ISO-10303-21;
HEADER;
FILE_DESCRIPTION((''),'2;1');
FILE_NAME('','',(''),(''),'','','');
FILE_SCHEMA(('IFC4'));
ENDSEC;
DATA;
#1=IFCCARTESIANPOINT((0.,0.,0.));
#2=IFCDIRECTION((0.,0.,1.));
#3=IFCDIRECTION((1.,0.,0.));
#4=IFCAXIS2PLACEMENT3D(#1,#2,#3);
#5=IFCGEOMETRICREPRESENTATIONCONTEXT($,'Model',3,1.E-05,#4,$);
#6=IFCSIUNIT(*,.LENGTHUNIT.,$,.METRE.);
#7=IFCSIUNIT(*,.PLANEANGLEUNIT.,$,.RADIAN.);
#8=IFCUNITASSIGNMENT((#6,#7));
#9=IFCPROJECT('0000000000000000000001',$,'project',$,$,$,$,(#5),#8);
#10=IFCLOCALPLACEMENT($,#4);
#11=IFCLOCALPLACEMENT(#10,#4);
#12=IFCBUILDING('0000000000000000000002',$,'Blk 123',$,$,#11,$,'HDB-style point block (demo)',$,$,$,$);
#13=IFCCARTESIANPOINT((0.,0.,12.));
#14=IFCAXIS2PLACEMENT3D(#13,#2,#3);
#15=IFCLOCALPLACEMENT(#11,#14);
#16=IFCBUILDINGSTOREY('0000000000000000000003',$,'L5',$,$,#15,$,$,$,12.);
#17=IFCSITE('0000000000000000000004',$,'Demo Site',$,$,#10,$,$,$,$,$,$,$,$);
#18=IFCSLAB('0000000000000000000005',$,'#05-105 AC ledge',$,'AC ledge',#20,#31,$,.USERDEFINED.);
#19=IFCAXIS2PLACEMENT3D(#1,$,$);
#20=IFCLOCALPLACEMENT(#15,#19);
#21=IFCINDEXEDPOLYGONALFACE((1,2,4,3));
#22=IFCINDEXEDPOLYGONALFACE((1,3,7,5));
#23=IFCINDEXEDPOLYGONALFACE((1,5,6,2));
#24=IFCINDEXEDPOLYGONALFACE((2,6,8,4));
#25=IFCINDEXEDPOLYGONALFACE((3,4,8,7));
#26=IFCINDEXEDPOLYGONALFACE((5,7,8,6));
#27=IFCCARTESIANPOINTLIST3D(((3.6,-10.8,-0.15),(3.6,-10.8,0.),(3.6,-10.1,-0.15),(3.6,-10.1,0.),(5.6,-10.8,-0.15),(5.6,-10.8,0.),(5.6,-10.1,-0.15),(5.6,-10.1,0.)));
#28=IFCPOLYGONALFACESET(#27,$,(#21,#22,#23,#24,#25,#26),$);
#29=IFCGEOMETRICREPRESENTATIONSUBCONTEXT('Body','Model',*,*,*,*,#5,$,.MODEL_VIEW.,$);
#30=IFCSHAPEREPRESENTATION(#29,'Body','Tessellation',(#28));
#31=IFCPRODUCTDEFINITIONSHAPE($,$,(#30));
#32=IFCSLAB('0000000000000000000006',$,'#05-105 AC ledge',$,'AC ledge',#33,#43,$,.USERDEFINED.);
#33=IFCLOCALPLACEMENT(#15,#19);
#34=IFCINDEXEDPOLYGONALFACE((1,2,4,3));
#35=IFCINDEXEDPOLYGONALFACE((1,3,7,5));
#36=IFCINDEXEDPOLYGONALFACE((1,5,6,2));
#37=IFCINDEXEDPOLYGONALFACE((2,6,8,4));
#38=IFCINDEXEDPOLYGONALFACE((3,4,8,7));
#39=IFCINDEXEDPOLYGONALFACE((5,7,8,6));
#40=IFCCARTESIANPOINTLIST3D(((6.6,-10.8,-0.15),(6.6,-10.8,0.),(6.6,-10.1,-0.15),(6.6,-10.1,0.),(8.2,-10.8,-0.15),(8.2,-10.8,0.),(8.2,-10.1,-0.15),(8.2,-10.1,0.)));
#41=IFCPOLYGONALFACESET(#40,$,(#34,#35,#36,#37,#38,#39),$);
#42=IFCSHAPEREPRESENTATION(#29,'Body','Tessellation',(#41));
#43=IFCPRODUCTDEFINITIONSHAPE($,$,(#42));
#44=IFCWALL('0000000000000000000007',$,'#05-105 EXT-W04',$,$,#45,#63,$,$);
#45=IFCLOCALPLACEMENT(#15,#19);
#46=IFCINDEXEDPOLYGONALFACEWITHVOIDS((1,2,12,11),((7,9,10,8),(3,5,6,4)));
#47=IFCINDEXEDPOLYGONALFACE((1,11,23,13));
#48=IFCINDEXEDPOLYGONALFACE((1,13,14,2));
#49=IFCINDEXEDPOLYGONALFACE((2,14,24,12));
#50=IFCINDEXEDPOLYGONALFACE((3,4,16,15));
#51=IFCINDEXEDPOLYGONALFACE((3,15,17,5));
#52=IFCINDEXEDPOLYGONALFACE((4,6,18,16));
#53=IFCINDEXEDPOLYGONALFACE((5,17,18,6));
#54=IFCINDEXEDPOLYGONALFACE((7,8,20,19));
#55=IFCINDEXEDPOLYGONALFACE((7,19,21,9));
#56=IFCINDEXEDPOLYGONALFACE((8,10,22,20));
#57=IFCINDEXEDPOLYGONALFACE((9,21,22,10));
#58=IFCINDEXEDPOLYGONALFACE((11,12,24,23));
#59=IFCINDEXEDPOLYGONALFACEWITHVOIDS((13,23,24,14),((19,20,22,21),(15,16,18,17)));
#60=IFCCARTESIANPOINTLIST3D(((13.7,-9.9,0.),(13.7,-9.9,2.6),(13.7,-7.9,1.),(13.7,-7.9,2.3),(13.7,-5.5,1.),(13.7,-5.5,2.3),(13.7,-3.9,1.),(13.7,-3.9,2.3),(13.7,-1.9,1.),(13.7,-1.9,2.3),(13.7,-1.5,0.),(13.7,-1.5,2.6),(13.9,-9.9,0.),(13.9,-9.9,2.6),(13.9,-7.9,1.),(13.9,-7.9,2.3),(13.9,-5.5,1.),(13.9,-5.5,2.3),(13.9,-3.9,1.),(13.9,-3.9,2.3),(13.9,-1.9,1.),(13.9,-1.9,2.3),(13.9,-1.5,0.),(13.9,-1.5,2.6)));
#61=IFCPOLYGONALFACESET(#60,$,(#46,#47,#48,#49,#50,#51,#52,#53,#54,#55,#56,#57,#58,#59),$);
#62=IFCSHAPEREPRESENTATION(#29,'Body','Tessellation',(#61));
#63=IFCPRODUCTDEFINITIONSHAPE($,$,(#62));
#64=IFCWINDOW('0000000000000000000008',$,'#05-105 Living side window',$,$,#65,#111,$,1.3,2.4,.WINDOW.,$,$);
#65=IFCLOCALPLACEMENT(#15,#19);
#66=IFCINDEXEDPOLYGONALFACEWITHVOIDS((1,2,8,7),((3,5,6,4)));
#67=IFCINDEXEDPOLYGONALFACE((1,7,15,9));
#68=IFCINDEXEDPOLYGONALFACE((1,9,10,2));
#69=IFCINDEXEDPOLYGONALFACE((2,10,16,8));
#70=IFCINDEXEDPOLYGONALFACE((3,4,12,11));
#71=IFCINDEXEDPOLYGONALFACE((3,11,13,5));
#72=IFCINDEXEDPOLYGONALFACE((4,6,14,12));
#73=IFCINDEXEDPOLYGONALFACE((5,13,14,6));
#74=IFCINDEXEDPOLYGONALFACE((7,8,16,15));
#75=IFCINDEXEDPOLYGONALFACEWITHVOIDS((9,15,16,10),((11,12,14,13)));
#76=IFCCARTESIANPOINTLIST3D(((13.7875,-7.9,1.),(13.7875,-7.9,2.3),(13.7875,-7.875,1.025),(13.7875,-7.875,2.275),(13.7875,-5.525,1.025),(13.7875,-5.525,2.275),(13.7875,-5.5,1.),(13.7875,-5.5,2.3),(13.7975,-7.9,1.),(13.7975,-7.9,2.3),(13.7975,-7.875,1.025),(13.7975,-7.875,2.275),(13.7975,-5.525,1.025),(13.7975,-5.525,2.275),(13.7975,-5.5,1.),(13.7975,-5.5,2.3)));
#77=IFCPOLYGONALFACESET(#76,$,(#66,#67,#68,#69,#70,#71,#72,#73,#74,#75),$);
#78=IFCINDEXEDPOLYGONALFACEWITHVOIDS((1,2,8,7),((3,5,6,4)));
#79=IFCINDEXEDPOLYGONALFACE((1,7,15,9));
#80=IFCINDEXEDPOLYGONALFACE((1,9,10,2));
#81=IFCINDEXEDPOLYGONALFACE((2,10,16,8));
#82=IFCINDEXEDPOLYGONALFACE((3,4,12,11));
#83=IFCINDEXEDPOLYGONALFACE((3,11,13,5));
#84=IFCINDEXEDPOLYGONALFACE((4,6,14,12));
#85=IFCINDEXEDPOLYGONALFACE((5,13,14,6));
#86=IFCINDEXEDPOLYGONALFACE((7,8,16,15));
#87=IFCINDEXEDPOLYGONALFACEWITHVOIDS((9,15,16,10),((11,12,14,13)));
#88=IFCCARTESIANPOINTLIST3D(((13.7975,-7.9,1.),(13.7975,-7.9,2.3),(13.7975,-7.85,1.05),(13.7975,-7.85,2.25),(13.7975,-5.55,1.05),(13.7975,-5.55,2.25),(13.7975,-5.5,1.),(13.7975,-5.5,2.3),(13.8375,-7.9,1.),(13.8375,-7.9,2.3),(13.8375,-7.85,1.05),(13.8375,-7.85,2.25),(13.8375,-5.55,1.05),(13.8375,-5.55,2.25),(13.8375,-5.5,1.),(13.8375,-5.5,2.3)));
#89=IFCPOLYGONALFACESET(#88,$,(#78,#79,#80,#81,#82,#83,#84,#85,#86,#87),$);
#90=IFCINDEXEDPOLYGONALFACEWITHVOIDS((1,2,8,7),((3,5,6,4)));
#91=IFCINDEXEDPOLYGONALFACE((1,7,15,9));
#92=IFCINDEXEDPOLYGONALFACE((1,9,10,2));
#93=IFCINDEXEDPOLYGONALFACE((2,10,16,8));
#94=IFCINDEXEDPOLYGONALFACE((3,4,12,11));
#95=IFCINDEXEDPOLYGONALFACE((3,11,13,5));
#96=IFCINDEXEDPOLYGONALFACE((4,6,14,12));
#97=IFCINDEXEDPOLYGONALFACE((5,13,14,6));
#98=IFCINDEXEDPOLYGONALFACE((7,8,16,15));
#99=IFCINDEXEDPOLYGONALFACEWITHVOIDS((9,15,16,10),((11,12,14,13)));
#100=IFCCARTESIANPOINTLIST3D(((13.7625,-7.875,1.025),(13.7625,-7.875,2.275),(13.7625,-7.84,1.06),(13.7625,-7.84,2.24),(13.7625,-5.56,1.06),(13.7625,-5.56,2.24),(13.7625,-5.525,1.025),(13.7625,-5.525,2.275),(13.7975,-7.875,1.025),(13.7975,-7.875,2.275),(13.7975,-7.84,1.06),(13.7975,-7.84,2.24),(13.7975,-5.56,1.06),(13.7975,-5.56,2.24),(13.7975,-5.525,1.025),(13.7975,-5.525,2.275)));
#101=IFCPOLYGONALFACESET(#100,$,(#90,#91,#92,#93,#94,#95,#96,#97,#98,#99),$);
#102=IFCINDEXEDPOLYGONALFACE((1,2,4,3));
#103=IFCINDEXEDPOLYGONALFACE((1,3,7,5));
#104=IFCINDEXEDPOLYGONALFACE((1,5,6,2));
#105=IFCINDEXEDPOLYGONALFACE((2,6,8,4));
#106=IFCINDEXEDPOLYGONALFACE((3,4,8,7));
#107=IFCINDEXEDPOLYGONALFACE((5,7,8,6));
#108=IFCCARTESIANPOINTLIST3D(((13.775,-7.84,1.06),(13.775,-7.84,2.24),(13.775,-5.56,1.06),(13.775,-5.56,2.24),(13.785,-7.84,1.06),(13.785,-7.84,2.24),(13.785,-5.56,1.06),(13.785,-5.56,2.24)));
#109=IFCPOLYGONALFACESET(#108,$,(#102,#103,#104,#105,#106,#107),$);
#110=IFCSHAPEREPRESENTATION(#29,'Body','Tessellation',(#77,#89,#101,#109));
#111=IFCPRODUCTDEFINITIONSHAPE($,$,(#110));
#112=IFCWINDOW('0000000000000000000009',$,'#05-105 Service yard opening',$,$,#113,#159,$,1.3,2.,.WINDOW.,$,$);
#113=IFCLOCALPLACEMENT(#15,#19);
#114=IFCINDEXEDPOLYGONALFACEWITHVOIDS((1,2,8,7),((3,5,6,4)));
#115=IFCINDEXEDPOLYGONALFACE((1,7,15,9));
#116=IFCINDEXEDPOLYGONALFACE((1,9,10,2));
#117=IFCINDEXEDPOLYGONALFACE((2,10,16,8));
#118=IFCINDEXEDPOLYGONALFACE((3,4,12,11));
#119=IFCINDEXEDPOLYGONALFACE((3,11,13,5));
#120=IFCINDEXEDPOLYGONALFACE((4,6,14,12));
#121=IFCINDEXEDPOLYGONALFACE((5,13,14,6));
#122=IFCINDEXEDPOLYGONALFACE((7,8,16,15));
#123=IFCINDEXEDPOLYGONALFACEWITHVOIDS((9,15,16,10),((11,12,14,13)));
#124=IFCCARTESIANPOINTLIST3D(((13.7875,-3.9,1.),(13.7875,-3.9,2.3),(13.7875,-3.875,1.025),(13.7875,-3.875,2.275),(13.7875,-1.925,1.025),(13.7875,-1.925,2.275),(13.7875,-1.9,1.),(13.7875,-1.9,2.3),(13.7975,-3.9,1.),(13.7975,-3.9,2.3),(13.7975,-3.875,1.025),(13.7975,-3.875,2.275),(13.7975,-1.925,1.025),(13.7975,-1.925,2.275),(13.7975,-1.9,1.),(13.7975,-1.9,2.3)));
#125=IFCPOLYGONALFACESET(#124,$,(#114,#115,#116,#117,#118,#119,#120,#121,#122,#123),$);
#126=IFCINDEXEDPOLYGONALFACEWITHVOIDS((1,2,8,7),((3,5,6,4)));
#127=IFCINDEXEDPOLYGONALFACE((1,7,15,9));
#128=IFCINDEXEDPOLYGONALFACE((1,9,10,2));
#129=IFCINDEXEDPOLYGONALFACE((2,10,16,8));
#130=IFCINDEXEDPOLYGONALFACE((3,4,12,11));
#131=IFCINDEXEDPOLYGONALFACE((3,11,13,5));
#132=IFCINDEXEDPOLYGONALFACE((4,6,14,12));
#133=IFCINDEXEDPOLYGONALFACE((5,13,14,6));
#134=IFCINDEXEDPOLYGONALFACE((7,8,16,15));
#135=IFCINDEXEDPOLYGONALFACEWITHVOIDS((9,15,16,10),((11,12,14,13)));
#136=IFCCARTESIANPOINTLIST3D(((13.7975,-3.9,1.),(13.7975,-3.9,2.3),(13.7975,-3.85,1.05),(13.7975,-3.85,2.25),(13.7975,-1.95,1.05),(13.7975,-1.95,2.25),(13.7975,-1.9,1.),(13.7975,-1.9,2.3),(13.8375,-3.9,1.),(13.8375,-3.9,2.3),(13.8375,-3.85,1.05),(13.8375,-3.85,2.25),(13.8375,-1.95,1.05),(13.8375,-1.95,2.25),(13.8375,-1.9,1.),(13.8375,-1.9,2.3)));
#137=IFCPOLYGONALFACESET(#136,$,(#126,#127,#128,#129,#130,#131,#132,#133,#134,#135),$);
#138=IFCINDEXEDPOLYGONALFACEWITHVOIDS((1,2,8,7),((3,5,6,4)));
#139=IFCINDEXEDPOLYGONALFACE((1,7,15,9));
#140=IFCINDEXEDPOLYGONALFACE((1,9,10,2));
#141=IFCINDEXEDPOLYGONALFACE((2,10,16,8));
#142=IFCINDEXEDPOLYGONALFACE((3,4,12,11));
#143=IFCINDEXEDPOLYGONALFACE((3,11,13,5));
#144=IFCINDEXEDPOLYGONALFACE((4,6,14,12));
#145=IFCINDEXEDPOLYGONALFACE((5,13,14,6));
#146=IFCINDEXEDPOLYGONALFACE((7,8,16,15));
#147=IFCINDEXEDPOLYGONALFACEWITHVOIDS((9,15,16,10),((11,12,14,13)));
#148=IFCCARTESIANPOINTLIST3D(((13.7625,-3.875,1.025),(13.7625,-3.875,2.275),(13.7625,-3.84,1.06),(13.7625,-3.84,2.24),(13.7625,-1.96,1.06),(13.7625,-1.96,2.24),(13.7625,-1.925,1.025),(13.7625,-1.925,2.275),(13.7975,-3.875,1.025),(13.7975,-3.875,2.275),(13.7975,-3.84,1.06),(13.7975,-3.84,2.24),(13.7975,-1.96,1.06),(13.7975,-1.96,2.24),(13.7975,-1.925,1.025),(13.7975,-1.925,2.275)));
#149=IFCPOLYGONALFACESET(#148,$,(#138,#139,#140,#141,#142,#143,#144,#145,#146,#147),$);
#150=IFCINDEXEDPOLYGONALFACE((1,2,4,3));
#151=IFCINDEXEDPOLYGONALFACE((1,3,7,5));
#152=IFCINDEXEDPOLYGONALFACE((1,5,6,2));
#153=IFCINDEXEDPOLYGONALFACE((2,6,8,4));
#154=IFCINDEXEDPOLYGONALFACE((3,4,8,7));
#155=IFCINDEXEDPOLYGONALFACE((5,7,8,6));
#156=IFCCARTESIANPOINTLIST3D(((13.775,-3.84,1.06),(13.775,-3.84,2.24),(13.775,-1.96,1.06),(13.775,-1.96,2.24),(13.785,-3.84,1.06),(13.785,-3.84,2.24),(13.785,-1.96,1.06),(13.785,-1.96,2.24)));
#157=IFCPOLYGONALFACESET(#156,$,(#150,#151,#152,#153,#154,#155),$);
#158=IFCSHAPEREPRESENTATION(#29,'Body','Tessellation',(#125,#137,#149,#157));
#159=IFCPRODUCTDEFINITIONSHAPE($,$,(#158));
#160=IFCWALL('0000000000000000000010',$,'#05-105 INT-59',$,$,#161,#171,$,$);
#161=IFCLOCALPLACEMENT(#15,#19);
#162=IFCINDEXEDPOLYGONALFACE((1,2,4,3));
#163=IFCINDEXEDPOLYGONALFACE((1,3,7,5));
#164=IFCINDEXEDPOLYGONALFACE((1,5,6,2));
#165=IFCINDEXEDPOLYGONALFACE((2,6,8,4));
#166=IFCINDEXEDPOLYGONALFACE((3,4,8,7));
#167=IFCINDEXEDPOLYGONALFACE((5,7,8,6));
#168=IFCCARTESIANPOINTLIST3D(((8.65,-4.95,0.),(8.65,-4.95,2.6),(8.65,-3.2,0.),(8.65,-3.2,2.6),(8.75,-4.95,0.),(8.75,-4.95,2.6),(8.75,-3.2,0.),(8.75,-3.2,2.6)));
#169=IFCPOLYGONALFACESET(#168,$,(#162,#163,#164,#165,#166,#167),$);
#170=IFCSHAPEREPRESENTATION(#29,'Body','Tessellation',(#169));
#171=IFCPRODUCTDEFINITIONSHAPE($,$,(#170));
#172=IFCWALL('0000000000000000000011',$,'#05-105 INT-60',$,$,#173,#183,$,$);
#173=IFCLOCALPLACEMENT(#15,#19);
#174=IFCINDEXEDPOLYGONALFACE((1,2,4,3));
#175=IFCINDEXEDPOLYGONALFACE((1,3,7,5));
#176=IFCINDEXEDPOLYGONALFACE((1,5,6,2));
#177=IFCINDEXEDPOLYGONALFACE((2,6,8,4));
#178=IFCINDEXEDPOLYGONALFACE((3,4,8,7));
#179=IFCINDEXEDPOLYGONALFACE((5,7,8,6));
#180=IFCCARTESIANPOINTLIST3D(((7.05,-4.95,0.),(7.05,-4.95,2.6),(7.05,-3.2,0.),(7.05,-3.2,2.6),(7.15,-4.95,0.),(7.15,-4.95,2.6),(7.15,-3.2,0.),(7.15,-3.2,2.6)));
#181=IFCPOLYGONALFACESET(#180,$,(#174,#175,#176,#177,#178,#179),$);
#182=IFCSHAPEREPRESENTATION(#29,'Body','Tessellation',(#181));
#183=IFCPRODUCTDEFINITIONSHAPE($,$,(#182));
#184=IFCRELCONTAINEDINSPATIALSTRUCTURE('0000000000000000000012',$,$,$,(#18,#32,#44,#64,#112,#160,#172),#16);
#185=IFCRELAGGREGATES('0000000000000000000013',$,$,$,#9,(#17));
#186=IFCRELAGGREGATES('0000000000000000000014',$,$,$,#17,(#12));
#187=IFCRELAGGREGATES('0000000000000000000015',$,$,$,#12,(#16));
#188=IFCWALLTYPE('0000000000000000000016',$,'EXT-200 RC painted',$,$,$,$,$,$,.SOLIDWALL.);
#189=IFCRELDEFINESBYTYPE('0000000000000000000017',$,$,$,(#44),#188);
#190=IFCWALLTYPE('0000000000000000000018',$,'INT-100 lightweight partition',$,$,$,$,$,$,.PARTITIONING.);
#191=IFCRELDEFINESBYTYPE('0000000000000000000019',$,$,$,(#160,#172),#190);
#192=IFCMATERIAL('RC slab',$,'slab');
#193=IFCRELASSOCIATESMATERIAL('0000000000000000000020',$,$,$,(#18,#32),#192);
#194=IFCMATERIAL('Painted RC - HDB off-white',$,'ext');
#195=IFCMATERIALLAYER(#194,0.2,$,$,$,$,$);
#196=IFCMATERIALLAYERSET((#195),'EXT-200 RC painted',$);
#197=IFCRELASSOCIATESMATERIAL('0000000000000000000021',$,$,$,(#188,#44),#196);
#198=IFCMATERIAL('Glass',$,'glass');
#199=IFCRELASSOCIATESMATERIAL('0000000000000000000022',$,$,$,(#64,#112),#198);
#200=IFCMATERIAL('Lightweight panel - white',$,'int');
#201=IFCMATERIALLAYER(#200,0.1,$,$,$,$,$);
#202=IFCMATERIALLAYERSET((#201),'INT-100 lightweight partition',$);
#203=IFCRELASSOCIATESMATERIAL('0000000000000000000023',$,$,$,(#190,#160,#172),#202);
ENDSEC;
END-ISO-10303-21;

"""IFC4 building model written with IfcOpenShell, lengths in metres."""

from ifc_helpers import new_model, si_unit, frame, origin, origin_with_axes, place, context, subcontext, project, spatial, polyline, line, indexed_curve, outline, extrude, material, layer, layer_set, layer_usage, type_object, element, fill, save


model = new_model("IFC4")

# Units and contexts
model_context = context("Model", 3, precision=1e-05, world=origin_with_axes())
body_context = subcontext(model_context, "Body", "Model", "MODEL_VIEW")
ifc_project = project(units=[si_unit("LENGTHUNIT", "METRE"), si_unit("PLANEANGLEUNIT", "RADIAN")], contexts=[model_context])

# Site, building, storey
site_placement = place(None, origin_with_axes())
site = spatial("IfcSite", under=ifc_project, at=site_placement, Name="Demo Site")
building_placement = place(site_placement, origin_with_axes())
building = spatial("IfcBuilding", under=site, at=building_placement, Name="Blk 123", LongName="HDB-style point block (demo)")
storey_placement = place(building_placement, frame((0.0, 0.0, 12.0), z_axis=(0.0, 0.0, 1.0), x_axis=(1.0, 0.0, 0.0)))
storey = spatial("IfcBuildingStorey", under=building, at=storey_placement, Name="L5", Elevation=12.0)

# Slabs
ifc_material_1 = material(Name="RC slab", Category="slab")
slab_1_placement = place(storey_placement, frame((4.6, -10.45, -0.15), z_axis=(0.0, 0.0, 1.0), x_axis=(1.0, 0.0, 0.0)))
element("IfcSlab", 1, at=slab_1_placement, inside=storey, material=ifc_material_1, Name="#05-105 AC ledge", ObjectType="AC ledge", PredefinedType="USERDEFINED", context=body_context, shape_type="SweptSolid", body=[
    extrude(outline(polyline([(1.0, 0.35), (-1.0, 0.35), (-1.0, -0.35), (1.0, -0.35), (1.0, 0.35)])), origin(), (0.0, 0.0, 1.0), 0.15),
])
slab_2_placement = place(storey_placement, frame((7.4, -10.45, -0.15), z_axis=(0.0, 0.0, 1.0), x_axis=(1.0, 0.0, 0.0)))
element("IfcSlab", 2, at=slab_2_placement, inside=storey, material=ifc_material_1, Name="#05-105 AC ledge", ObjectType="AC ledge", PredefinedType="USERDEFINED", context=body_context, shape_type="SweptSolid", body=[
    extrude(outline(polyline([(0.8, 0.35), (-0.8, 0.35), (-0.8, -0.35), (0.8, -0.35), (0.8, 0.35)])), origin(), (0.0, 0.0, 1.0), 0.15),
])

# Wall, openings, windows
ifc_material_2 = material(Name="Painted RC - HDB off-white", Category="ext")
ifc_layer_1 = layer(ifc_material_2, 0.2)
ifc_layer_set_1 = layer_set([ifc_layer_1], Name="EXT-200 RC painted")
ifc_layer_usage_1 = layer_usage(ifc_layer_set_1, "AXIS2", "POSITIVE", 0.0)
wall_type_1 = type_object("IfcWallType", Name="EXT-200 RC painted", PredefinedType="SOLIDWALL", material=ifc_layer_set_1)
wall_1_placement = place(storey_placement, frame((13.9, -9.9, 0.0), z_axis=(0.0, 0.0, 1.0), x_axis=(0.0, 1.0, 0.0)))
wall_1 = element("IfcWall", 3, at=wall_1_placement, inside=storey, type_object=wall_type_1, material=ifc_layer_usage_1, Name="#05-105 EXT-W04", context=body_context, shape_type="SweptSolid", body=[
    extrude(outline(indexed_curve([(0.0, 0.0), (0.0, 0.2), (8.4, 0.2), (8.4, 0.0), (0.0, 0.0)], self_intersect=False)), origin_with_axes(), (0.0, 0.0, 1.0), 2.6),
])
opening_1_placement = place(wall_1_placement, frame((2.0, -0.1, 1.0), z_axis=(0.0, 0.0, 1.0), x_axis=(1.0, 0.0, 0.0)))
opening_1 = element("IfcOpeningElement", 4, at=opening_1_placement, cuts=wall_1, context=body_context, shape_type="SweptSolid", body=[
    extrude(outline(indexed_curve([(0.0, 0.0), (0.0, 0.4), (2.4, 0.4), (2.4, 0.0), (0.0, 0.0)], self_intersect=False)), origin_with_axes(), (0.0, 0.0, 1.0), 1.3),
])
opening_2_placement = place(wall_1_placement, frame((6.0, -0.1, 1.0), z_axis=(0.0, 0.0, 1.0), x_axis=(1.0, 0.0, 0.0)))
opening_2 = element("IfcOpeningElement", 5, at=opening_2_placement, cuts=wall_1, context=body_context, shape_type="SweptSolid", body=[
    extrude(outline(indexed_curve([(0.0, 0.0), (0.0, 0.4), (2.0, 0.4), (2.0, 0.0), (0.0, 0.0)], self_intersect=False)), origin_with_axes(), (0.0, 0.0, 1.0), 1.3),
])
ifc_material_3 = material(Name="Glass", Category="glass")
window_1_placement = place(opening_1_placement, frame((0.0, 0.1125, 0.0), z_axis=(0.0, 0.0, 1.0), x_axis=(1.0, 0.0, 0.0)))
window_1 = element("IfcWindow", 6, at=window_1_placement, inside=storey, material=ifc_material_3, Name="#05-105 Living side window", OverallHeight=1.3, OverallWidth=2.4, PredefinedType="WINDOW", context=body_context, shape_type="SweptSolid", body=[
    extrude(outline(indexed_curve([(0.0, 0.0), (2.4, 0.0), (2.4, 1.3), (0.0, 1.3)], segments=[line(1, 2, 3, 4, 1)]), holes=[indexed_curve([(0.025, 0.025), (2.375, 0.025), (2.375, 1.275), (0.025, 1.275)], segments=[line(1, 2, 3, 4, 1)])]), frame((0.0, 0.09, 0.0), z_axis=(0.0, -1.0, 0.0), x_axis=(1.0, 0.0, 0.0)), (0.0, 0.0, -1.0), 0.01),
    extrude(outline(indexed_curve([(0.0, 0.0), (2.4, 0.0), (2.4, 1.3), (0.0, 1.3)], segments=[line(1, 2, 3, 4, 1)]), holes=[indexed_curve([(0.05, 0.05), (2.35, 0.05), (2.35, 1.25), (0.05, 1.25)], segments=[line(1, 2, 3, 4, 1)])]), frame((0.0, 0.05, 0.0), z_axis=(0.0, -1.0, 0.0), x_axis=(1.0, 0.0, 0.0)), (0.0, 0.0, -1.0), 0.04),
    extrude(outline(indexed_curve([(0.0, 0.0), (2.35, 0.0), (2.35, 1.25), (0.0, 1.25)], segments=[line(1, 2, 3, 4, 1)]), holes=[indexed_curve([(0.035, 0.035), (2.315, 0.035), (2.315, 1.215), (0.035, 1.215)], segments=[line(1, 2, 3, 4, 1)])]), frame((0.025, 0.09, 0.025), z_axis=(0.0, -1.0, 0.0), x_axis=(1.0, 0.0, 0.0)), (0.0, 0.0, -1.0), 0.035),
    extrude(outline(indexed_curve([(0.035, 0.035), (2.315, 0.035), (2.315, 1.215), (0.035, 1.215)], segments=[line(1, 2, 3, 4, 1)])), frame((0.025, 0.1025, 0.025), z_axis=(0.0, -1.0, 0.0), x_axis=(1.0, 0.0, 0.0)), (0.0, 0.0, -1.0), 0.01),
])
fill(opening_1, window_1)
window_2_placement = place(opening_2_placement, frame((0.0, 0.1125, 0.0), z_axis=(0.0, 0.0, 1.0), x_axis=(1.0, 0.0, 0.0)))
window_2 = element("IfcWindow", 7, at=window_2_placement, inside=storey, material=ifc_material_3, Name="#05-105 Service yard opening", OverallHeight=1.3, OverallWidth=2.0, PredefinedType="WINDOW", context=body_context, shape_type="SweptSolid", body=[
    extrude(outline(indexed_curve([(0.0, 0.0), (2.0, 0.0), (2.0, 1.3), (0.0, 1.3)], segments=[line(1, 2, 3, 4, 1)]), holes=[indexed_curve([(0.025, 0.025), (1.975, 0.025), (1.975, 1.275), (0.025, 1.275)], segments=[line(1, 2, 3, 4, 1)])]), frame((0.0, 0.09, 0.0), z_axis=(0.0, -1.0, 0.0), x_axis=(1.0, 0.0, 0.0)), (0.0, 0.0, -1.0), 0.01),
    extrude(outline(indexed_curve([(0.0, 0.0), (2.0, 0.0), (2.0, 1.3), (0.0, 1.3)], segments=[line(1, 2, 3, 4, 1)]), holes=[indexed_curve([(0.05, 0.05), (1.95, 0.05), (1.95, 1.25), (0.05, 1.25)], segments=[line(1, 2, 3, 4, 1)])]), frame((0.0, 0.05, 0.0), z_axis=(0.0, -1.0, 0.0), x_axis=(1.0, 0.0, 0.0)), (0.0, 0.0, -1.0), 0.04),
    extrude(outline(indexed_curve([(0.0, 0.0), (1.95, 0.0), (1.95, 1.25), (0.0, 1.25)], segments=[line(1, 2, 3, 4, 1)]), holes=[indexed_curve([(0.035, 0.035), (1.915, 0.035), (1.915, 1.215), (0.035, 1.215)], segments=[line(1, 2, 3, 4, 1)])]), frame((0.025, 0.09, 0.025), z_axis=(0.0, -1.0, 0.0), x_axis=(1.0, 0.0, 0.0)), (0.0, 0.0, -1.0), 0.035),
    extrude(outline(indexed_curve([(0.035, 0.035), (1.915, 0.035), (1.915, 1.215), (0.035, 1.215)], segments=[line(1, 2, 3, 4, 1)])), frame((0.025, 0.1025, 0.025), z_axis=(0.0, -1.0, 0.0), x_axis=(1.0, 0.0, 0.0)), (0.0, 0.0, -1.0), 0.01),
])
fill(opening_2, window_2)

# Walls
ifc_material_4 = material(Name="Lightweight panel - white", Category="int")
ifc_layer_2 = layer(ifc_material_4, 0.1)
ifc_layer_set_2 = layer_set([ifc_layer_2], Name="INT-100 lightweight partition")
ifc_layer_usage_2 = layer_usage(ifc_layer_set_2, "AXIS2", "POSITIVE", -0.05)
wall_type_2 = type_object("IfcWallType", Name="INT-100 lightweight partition", PredefinedType="PARTITIONING", material=ifc_layer_set_2)
for number, where, z_axis, x_axis, name in (
    (8, (8.7, -3.2, 0.0), (0.0, 0.0, 1.0), (0.0, -1.0, 0.0), "#05-105 INT-59"),
    (9, (7.1, -3.2, 0.0), (0.0, 0.0, 1.0), (0.0, -1.0, 0.0), "#05-105 INT-60"),
):
    element("IfcWall", number, at=place(storey_placement, frame(where, z_axis=z_axis, x_axis=x_axis)), inside=storey, type_object=wall_type_2, material=ifc_layer_usage_2, Name=name, context=body_context, shape_type="SweptSolid", body=[
        extrude(outline(indexed_curve([(0.0, 0.0), (0.0, 0.1), (1.75, 0.1), (1.75, 0.0), (0.0, 0.0)], self_intersect=False)), frame((0.0, -0.05, 0.0), z_axis=(0.0, 0.0, 1.0), x_axis=(1.0, 0.0, 0.0)), (0.0, 0.0, 1.0), 2.6),
    ])

save(model, "model.ifc")
